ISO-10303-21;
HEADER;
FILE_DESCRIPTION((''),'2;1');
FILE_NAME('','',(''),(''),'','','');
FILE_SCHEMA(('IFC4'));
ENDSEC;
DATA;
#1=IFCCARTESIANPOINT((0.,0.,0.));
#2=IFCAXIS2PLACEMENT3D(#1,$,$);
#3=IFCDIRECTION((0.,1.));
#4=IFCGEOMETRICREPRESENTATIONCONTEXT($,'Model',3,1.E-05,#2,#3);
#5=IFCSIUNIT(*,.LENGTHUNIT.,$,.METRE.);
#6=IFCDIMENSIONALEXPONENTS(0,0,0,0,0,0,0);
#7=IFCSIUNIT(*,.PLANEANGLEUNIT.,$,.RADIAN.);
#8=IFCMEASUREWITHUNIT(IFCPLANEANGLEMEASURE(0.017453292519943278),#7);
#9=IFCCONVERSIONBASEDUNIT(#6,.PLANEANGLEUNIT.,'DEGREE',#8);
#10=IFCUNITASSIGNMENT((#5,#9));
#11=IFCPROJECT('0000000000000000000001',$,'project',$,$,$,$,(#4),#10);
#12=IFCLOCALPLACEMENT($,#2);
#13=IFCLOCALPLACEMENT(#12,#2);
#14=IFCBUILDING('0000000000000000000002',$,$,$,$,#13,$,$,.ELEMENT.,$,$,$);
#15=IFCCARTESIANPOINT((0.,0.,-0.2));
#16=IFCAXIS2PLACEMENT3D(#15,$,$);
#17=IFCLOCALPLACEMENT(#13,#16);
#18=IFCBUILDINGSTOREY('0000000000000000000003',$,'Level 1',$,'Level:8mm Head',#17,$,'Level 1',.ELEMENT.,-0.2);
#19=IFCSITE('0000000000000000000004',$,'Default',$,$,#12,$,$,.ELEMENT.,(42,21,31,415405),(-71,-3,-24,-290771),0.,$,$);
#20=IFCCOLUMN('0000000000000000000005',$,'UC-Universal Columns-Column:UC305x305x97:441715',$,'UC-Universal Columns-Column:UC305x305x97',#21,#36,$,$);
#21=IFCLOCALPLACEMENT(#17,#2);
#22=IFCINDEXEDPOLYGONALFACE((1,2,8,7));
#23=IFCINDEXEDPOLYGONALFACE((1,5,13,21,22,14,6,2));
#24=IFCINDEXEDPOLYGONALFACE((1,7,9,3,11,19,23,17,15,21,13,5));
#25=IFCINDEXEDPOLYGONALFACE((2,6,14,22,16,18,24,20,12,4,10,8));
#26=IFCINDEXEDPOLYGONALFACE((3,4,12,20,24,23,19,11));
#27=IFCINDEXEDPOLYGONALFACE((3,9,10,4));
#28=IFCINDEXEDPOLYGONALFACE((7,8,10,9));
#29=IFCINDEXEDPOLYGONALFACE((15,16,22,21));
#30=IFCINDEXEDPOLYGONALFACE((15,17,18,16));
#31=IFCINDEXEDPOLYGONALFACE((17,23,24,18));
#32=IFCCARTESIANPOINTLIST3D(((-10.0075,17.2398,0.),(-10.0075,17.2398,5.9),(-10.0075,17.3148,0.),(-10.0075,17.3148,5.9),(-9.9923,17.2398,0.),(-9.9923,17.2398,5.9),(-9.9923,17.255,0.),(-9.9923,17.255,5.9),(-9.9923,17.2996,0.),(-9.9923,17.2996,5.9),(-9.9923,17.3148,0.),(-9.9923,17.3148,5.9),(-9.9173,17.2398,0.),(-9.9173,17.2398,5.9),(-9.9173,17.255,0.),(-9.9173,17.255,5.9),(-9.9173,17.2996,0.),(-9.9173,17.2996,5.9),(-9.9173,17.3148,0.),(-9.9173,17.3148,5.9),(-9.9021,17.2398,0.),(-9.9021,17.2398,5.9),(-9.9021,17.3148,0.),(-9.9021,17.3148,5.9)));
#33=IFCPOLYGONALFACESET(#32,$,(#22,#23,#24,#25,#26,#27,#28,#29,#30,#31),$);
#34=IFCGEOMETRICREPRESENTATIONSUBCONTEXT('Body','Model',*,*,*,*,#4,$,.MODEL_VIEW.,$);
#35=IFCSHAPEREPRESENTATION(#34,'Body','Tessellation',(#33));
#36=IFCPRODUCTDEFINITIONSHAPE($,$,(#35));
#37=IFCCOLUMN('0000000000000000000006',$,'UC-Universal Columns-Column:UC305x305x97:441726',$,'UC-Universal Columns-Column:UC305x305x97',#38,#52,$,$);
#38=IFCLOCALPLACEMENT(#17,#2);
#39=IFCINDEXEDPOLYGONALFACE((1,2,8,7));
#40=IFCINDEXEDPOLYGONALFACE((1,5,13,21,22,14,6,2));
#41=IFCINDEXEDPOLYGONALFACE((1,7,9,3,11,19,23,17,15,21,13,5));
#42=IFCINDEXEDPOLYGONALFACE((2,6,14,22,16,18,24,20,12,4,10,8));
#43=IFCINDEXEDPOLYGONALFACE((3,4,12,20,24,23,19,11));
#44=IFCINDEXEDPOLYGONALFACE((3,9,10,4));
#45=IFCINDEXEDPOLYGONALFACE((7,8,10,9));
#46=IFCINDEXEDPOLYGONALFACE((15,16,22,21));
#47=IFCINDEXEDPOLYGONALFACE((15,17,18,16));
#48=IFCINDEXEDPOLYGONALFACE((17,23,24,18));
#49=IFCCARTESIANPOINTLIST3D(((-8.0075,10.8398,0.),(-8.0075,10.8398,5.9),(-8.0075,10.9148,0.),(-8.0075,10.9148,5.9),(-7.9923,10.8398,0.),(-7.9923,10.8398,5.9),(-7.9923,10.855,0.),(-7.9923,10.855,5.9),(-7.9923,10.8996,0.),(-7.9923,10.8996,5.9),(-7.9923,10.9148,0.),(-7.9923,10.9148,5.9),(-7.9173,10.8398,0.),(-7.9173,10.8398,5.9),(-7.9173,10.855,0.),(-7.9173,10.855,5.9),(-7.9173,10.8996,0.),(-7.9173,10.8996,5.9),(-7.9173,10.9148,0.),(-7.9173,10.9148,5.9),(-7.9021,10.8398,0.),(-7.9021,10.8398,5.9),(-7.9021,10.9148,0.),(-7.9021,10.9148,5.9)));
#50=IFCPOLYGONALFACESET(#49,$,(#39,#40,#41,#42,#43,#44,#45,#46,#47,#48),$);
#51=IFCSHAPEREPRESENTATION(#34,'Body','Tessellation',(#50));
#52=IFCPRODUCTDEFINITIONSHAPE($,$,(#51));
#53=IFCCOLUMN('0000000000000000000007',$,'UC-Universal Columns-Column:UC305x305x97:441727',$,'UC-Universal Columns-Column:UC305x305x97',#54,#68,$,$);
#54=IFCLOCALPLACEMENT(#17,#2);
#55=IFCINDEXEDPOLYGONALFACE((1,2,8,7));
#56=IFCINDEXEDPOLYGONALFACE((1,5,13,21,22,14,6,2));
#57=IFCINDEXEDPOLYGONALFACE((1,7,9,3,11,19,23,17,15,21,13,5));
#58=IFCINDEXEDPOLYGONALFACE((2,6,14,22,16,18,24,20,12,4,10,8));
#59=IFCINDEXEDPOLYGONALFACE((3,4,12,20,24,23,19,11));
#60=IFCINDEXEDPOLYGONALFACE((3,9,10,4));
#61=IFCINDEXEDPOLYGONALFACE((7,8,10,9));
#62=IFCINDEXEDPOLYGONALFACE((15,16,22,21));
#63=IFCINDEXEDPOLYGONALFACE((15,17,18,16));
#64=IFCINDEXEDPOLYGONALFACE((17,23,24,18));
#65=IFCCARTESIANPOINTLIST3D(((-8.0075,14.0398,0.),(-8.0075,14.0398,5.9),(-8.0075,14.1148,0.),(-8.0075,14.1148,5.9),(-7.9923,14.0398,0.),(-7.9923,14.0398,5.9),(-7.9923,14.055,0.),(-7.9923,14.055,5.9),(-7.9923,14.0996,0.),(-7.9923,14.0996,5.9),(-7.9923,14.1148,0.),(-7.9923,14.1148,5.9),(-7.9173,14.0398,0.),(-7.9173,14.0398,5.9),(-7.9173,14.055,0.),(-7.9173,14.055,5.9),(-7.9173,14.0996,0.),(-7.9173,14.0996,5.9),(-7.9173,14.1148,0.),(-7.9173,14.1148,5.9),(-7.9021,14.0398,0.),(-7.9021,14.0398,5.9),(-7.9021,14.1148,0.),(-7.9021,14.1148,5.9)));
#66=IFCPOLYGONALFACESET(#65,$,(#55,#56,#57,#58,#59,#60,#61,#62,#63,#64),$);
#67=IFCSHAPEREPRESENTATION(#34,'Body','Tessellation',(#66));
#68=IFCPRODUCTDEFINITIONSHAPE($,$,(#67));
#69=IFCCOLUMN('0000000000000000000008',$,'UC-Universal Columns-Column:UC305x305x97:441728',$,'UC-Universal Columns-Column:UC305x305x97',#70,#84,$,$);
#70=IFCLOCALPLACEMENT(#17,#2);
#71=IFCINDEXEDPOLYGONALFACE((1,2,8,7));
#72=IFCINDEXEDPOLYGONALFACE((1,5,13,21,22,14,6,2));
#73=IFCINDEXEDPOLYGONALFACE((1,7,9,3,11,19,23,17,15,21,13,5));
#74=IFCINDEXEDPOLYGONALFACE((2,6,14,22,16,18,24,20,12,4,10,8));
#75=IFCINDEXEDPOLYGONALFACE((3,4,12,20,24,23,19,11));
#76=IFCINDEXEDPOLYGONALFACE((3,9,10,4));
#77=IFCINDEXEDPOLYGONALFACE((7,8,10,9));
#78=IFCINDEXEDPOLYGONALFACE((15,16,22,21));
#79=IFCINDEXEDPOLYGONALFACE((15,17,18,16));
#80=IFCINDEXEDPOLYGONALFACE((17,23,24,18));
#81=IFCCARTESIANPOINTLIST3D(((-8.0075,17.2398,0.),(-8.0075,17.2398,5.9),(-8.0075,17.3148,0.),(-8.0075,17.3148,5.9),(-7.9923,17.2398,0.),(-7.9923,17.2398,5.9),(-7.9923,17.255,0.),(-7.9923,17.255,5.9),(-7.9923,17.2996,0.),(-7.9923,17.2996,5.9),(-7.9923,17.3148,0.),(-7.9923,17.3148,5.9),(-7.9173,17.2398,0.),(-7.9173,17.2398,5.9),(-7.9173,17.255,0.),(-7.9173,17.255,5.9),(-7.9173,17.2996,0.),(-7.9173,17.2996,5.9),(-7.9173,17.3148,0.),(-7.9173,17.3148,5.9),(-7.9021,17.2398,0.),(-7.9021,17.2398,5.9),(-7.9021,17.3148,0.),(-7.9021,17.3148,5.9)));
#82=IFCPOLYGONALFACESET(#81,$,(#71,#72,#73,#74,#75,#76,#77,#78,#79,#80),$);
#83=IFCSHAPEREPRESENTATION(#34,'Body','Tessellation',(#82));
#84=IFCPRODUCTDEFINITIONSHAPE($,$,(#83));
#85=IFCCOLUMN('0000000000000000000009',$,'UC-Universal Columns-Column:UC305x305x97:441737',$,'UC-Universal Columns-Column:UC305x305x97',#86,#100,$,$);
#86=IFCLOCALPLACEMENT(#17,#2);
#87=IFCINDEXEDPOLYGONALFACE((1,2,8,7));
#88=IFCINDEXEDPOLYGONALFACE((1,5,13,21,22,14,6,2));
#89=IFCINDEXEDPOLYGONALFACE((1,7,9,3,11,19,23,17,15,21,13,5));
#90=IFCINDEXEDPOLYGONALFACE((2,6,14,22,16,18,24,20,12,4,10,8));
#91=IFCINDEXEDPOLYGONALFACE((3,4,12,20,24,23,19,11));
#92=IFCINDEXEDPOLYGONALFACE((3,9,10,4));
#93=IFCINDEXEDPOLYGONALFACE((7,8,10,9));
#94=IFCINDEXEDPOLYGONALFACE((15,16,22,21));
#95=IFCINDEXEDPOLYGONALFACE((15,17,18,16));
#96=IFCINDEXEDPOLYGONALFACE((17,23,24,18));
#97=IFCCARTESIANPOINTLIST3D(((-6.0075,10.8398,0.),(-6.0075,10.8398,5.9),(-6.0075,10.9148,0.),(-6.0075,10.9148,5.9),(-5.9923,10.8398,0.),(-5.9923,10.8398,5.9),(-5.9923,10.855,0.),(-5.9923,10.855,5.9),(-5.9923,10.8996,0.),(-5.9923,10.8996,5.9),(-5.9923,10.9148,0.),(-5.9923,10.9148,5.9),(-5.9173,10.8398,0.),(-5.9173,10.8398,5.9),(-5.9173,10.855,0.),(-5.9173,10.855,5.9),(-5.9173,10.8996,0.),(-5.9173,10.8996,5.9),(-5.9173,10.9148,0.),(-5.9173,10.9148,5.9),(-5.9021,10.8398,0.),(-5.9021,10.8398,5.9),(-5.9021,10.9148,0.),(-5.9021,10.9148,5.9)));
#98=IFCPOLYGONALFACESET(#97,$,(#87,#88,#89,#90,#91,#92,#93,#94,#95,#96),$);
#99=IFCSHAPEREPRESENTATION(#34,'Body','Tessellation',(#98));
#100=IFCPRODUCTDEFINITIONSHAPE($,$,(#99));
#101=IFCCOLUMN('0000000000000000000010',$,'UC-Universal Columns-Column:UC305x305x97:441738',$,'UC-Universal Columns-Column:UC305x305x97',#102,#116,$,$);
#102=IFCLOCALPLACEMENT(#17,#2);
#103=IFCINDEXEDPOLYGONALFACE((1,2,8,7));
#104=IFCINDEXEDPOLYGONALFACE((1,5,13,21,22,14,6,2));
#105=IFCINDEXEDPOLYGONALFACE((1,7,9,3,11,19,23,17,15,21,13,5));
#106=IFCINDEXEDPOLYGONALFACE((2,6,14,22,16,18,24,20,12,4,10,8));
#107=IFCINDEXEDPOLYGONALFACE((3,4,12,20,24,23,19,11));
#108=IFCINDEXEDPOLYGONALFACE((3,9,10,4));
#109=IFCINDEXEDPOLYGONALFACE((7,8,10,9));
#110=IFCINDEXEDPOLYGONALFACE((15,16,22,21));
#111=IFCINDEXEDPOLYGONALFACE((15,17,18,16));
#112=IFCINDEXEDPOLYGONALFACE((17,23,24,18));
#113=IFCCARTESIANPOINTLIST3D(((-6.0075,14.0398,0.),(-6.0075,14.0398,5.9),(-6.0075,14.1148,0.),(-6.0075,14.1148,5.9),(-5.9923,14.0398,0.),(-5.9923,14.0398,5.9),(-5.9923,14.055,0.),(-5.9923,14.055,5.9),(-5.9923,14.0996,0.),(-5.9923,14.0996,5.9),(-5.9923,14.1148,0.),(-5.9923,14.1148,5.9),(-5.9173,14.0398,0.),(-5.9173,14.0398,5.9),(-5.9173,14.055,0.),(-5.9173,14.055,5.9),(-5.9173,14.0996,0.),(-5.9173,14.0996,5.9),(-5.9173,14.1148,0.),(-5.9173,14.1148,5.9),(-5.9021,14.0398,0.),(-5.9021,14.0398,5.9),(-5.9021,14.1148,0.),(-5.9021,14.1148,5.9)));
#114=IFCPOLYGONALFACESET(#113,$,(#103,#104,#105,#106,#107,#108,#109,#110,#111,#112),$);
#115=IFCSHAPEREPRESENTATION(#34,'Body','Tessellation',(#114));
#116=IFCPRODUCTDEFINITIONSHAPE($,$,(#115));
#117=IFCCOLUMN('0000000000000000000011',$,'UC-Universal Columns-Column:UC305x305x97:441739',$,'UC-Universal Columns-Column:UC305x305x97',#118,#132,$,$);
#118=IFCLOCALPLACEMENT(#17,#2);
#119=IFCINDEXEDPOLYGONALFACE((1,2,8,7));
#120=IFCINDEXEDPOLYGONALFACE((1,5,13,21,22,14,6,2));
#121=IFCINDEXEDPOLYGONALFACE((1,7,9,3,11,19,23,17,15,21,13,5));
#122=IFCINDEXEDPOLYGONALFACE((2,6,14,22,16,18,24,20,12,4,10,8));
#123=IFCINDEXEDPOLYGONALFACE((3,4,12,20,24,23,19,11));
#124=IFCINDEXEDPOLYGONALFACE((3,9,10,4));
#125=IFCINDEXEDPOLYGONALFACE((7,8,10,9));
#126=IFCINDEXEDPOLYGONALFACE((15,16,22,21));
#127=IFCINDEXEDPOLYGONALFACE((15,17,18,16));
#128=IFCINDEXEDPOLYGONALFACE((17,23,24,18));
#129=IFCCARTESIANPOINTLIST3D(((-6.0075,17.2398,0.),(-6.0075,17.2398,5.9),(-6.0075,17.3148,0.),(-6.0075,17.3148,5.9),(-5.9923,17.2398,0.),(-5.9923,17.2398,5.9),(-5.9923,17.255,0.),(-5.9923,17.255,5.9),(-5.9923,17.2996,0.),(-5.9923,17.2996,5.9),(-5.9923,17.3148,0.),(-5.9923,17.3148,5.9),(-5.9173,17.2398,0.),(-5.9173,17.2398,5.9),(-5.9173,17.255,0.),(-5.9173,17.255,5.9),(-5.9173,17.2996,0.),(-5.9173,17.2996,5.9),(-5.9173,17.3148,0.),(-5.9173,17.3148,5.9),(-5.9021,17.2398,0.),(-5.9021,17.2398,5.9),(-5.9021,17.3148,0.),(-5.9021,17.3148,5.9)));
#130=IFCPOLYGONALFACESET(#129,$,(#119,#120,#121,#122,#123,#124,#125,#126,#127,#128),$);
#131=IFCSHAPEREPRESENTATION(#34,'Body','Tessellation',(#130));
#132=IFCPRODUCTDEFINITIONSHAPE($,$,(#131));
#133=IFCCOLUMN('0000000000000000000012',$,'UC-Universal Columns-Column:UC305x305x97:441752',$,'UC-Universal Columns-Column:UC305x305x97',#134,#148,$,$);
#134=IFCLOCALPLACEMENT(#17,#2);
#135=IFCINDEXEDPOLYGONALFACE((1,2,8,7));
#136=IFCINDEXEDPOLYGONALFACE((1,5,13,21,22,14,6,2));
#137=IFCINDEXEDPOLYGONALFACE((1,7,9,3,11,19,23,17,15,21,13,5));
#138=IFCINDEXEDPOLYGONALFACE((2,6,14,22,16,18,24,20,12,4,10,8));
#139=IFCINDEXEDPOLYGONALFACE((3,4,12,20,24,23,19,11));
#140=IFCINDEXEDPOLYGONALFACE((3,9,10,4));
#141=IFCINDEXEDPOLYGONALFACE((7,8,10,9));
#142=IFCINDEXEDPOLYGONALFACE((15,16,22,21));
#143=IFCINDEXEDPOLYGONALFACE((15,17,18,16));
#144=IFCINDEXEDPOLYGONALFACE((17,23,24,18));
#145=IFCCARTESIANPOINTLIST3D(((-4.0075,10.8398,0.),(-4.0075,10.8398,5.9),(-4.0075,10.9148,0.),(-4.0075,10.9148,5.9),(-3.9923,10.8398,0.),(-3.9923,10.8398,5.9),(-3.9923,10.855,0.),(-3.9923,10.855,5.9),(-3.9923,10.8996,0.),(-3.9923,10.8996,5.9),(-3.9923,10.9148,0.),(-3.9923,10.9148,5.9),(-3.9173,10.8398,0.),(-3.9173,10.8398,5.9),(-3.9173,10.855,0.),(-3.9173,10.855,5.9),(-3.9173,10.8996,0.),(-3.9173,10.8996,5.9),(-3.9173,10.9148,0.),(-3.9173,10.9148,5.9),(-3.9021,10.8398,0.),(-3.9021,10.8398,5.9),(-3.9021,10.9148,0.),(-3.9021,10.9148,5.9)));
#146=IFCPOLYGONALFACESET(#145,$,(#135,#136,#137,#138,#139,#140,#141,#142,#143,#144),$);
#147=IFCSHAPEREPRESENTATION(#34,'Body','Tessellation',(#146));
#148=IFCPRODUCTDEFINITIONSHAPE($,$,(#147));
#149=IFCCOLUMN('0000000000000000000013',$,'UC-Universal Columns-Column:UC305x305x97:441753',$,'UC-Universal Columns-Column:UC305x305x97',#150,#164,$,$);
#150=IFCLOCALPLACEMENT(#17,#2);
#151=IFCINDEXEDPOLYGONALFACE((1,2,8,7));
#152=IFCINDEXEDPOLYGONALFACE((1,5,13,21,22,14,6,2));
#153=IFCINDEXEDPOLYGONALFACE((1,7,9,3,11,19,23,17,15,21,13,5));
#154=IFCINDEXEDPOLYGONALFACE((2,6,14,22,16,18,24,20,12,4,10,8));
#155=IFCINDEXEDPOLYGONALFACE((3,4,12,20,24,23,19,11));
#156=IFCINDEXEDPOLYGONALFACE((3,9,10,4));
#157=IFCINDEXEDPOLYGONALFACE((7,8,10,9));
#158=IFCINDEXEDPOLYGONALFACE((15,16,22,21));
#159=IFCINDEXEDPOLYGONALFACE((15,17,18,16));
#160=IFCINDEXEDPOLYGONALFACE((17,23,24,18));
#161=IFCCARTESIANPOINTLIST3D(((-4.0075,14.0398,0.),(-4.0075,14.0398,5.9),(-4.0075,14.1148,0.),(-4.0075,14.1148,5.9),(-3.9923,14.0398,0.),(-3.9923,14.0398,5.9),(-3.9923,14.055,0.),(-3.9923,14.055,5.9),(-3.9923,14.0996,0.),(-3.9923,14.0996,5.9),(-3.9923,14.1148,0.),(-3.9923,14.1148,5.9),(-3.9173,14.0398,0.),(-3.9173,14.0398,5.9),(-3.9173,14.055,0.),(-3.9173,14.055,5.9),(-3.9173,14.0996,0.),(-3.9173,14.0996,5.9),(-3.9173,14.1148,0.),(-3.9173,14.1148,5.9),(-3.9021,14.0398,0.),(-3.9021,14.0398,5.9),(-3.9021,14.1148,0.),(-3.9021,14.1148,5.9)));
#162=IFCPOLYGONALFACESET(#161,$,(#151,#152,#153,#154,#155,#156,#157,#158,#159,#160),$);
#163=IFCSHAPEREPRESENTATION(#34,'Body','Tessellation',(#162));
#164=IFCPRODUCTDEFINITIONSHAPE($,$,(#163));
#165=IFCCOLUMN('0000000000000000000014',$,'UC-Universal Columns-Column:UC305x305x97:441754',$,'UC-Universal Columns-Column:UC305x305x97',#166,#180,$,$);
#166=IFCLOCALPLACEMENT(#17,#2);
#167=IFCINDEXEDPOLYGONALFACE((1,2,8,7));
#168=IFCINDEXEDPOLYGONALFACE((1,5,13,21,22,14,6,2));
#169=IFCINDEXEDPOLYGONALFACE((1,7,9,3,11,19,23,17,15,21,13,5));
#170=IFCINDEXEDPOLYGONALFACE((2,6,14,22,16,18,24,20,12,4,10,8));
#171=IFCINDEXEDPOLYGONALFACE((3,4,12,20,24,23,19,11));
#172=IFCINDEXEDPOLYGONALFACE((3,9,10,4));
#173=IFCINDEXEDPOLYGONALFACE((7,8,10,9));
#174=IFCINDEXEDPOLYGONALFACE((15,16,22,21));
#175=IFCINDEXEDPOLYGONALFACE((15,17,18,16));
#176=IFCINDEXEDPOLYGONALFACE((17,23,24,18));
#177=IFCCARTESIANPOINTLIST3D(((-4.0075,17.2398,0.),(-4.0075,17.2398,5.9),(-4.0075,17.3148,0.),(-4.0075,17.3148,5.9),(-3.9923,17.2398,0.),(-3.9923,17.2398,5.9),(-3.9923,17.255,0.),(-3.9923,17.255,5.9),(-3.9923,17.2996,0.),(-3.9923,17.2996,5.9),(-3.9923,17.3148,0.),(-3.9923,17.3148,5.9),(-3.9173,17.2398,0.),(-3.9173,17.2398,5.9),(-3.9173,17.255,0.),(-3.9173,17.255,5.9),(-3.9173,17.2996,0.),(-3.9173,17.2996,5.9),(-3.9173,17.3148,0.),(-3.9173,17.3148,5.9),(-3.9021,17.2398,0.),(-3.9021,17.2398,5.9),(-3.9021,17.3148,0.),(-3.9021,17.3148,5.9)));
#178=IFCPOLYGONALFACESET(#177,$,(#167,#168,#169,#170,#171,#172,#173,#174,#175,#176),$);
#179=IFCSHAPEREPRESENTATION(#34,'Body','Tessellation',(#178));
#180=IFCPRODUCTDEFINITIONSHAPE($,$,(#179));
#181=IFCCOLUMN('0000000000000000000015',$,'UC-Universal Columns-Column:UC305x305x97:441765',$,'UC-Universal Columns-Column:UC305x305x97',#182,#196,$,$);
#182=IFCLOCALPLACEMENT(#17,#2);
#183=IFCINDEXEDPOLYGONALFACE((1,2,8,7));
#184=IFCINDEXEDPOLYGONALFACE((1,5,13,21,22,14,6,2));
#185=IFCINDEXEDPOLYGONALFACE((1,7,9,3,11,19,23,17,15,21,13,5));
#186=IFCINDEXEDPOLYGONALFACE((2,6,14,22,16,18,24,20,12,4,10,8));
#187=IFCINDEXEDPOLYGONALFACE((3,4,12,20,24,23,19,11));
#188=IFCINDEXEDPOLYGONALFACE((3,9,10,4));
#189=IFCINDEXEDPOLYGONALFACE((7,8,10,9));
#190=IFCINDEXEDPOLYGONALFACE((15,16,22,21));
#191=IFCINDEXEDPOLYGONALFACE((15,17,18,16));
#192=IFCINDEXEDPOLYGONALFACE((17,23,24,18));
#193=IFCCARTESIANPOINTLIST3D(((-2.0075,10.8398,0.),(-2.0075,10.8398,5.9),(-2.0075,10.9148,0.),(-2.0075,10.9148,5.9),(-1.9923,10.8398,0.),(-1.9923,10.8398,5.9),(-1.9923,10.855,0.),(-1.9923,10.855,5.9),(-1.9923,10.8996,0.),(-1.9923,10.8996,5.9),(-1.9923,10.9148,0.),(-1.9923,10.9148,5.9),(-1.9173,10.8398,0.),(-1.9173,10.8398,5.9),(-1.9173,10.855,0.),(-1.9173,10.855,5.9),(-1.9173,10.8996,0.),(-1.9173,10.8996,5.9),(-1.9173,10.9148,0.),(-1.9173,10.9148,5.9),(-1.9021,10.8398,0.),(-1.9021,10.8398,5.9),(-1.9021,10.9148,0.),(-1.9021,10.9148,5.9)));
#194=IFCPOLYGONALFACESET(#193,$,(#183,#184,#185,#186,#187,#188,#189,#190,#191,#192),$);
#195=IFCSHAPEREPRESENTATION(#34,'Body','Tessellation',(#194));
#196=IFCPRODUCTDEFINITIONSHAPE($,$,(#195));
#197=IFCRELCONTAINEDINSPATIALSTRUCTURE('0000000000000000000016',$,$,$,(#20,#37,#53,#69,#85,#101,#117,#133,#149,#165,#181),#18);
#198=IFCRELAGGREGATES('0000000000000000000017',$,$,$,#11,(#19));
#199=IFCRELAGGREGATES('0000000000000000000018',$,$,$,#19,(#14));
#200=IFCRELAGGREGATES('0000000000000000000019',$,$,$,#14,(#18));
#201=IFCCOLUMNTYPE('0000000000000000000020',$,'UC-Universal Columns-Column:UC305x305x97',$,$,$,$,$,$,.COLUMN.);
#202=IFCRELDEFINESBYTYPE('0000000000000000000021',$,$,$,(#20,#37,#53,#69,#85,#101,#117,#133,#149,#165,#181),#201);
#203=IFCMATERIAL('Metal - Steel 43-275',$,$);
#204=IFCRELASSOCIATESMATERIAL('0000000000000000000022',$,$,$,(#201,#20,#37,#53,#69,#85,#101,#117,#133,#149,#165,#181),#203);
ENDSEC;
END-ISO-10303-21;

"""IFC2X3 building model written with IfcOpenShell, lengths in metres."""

from ifc_helpers import new_model, entity, si_unit, converted_unit, direction, frame, frame_2d, origin, place, context, subcontext, project, spatial, polyline, circle_curve, parameter, trimmed, segment, composite_curve, outline, extrude, source, transform, mapped, material, type_object, type_shapes, element, save


model = new_model("IFC2X3")

# Units and contexts
model_context = context("Model", 3, precision=1e-05, world=origin(), true_north=direction((0.0, 1.0)))
body_context = subcontext(model_context, "Body", "Model", "MODEL_VIEW")
ifc_project = project(units=[si_unit("LENGTHUNIT", "METRE"), converted_unit("PLANEANGLEUNIT", "DEGREE", entity("IfcPlaneAngleMeasure", 0.017453292519943278), si_unit("PLANEANGLEUNIT", "RADIAN"), dimensions=[0, 0, 0, 0, 0, 0, 0])], contexts=[model_context])

# Site, building, storey
site_placement = place(None, origin())
site = spatial("IfcSite", under=ifc_project, at=site_placement, Name="Default", CompositionType="ELEMENT", RefLatitude=(42, 21, 31, 415405), RefLongitude=(-71, -3, -24, -290771), RefElevation=0.0)
building_placement = place(site_placement, origin())
building = spatial("IfcBuilding", under=site, at=building_placement, CompositionType="ELEMENT")
storey_placement = place(building_placement, frame((0.0, 0.0, -0.2)))
storey = spatial("IfcBuildingStorey", under=building, at=storey_placement, Name="Level 1", ObjectType="Level:8mm Head", LongName="Level 1", CompositionType="ELEMENT", Elevation=-0.2)

# Columns
ifc_material = material(Name="Metal - Steel 43-275")
column_type = type_object("IfcColumnType", Name="UC-Universal Columns-Column:UC305x305x97", PredefinedType="COLUMN", material=ifc_material)
shared_shape = source(origin(), body_context, "Body", "SweptSolid", [
    extrude(outline(composite_curve([segment(polyline([(-0.0375, -0.0375), (0.0375, -0.0375)]), True, "CONTINUOUS"), segment(polyline([(0.0375, -0.0375), (0.0527, -0.0375)]), True, "CONTINUOUS"), segment(trimmed(circle_curve(frame_2d((0.0527, -0.0223), x_axis=(-1.0, 0.0)), 0.0152), [parameter(0.0)], [parameter(90.0)], True, "PARAMETER"), False, "CONTINUOUS"), segment(polyline([(0.0375, -0.0223), (0.0375, 0.0223)]), True, "CONTINUOUS"), segment(trimmed(circle_curve(frame_2d((0.0527, 0.0223), x_axis=(-1.0, 0.0)), 0.0152), [parameter(270.0)], [parameter(0.0)], True, "PARAMETER"), False, "CONTINUOUS"), segment(polyline([(0.0527, 0.0375), (0.0375, 0.0375)]), True, "CONTINUOUS"), segment(polyline([(0.0375, 0.0375), (-0.0375, 0.0375)]), True, "CONTINUOUS"), segment(polyline([(-0.0375, 0.0375), (-0.0527, 0.0375)]), True, "CONTINUOUS"), segment(trimmed(circle_curve(frame_2d((-0.0527, 0.0223), x_axis=(-1.0, 0.0)), 0.0152), [parameter(180.0)], [parameter(270.0)], True, "PARAMETER"), False, "CONTINUOUS"), segment(polyline([(-0.0375, 0.0223), (-0.0375, -0.0223)]), True, "CONTINUOUS"), segment(trimmed(circle_curve(frame_2d((-0.0527, -0.0223), x_axis=(-1.0, 0.0)), 0.0152), [parameter(90.0)], [parameter(180.0)], True, "PARAMETER"), False, "CONTINUOUS"), segment(polyline([(-0.0527, -0.0375), (-0.0375, -0.0375)]), True, "CONTINUOUS")], self_intersect=False)), frame((0.0, 0.0, -0.2), z_axis=(0.0, 0.0, 1.0), x_axis=(-1.0, 0.0, 0.0)), (0.0, 0.0, 1.0), 5.9),
])
type_shapes(column_type, [shared_shape])
for number, where, z_axis, x_axis, name in (
    (1, (-9.9548, 17.2773, 0.2), (0.0, 0.0, 1.0), (-1.0, 0.0, 0.0), "UC-Universal Columns-Column:UC305x305x97:441715"),
    (2, (-7.9548, 10.8773, 0.2), (0.0, 0.0, 1.0), (-1.0, 0.0, 0.0), "UC-Universal Columns-Column:UC305x305x97:441726"),
    (3, (-7.9548, 14.0773, 0.2), (0.0, 0.0, 1.0), (-1.0, 0.0, 0.0), "UC-Universal Columns-Column:UC305x305x97:441727"),
    (4, (-7.9548, 17.2773, 0.2), (0.0, 0.0, 1.0), (-1.0, 0.0, 0.0), "UC-Universal Columns-Column:UC305x305x97:441728"),
    (5, (-5.9548, 10.8773, 0.2), (0.0, 0.0, 1.0), (-1.0, 0.0, 0.0), "UC-Universal Columns-Column:UC305x305x97:441737"),
    (6, (-5.9548, 14.0773, 0.2), (0.0, 0.0, 1.0), (-1.0, 0.0, 0.0), "UC-Universal Columns-Column:UC305x305x97:441738"),
    (7, (-5.9548, 17.2773, 0.2), (0.0, 0.0, 1.0), (-1.0, 0.0, 0.0), "UC-Universal Columns-Column:UC305x305x97:441739"),
    (8, (-3.9548, 10.8773, 0.2), (0.0, 0.0, 1.0), (-1.0, 0.0, 0.0), "UC-Universal Columns-Column:UC305x305x97:441752"),
    (9, (-3.9548, 14.0773, 0.2), (0.0, 0.0, 1.0), (-1.0, 0.0, 0.0), "UC-Universal Columns-Column:UC305x305x97:441753"),
    (10, (-3.9548, 17.2773, 0.2), (0.0, 0.0, 1.0), (-1.0, 0.0, 0.0), "UC-Universal Columns-Column:UC305x305x97:441754"),
    (11, (-1.9548, 10.8773, 0.2), (0.0, 0.0, 1.0), (-1.0, 0.0, 0.0), "UC-Universal Columns-Column:UC305x305x97:441765"),
):
    element("IfcColumn", number, at=place(storey_placement, frame(where, z_axis=z_axis, x_axis=x_axis)), inside=storey, type_object=column_type, material=ifc_material, Name=name, ObjectType="UC-Universal Columns-Column:UC305x305x97", context=body_context, shape_type="MappedRepresentation", body=[
        mapped(shared_shape, transform((0.0, 0.0, 0.0), scale=1.0)),
    ])

save(model, "model.ifc")
